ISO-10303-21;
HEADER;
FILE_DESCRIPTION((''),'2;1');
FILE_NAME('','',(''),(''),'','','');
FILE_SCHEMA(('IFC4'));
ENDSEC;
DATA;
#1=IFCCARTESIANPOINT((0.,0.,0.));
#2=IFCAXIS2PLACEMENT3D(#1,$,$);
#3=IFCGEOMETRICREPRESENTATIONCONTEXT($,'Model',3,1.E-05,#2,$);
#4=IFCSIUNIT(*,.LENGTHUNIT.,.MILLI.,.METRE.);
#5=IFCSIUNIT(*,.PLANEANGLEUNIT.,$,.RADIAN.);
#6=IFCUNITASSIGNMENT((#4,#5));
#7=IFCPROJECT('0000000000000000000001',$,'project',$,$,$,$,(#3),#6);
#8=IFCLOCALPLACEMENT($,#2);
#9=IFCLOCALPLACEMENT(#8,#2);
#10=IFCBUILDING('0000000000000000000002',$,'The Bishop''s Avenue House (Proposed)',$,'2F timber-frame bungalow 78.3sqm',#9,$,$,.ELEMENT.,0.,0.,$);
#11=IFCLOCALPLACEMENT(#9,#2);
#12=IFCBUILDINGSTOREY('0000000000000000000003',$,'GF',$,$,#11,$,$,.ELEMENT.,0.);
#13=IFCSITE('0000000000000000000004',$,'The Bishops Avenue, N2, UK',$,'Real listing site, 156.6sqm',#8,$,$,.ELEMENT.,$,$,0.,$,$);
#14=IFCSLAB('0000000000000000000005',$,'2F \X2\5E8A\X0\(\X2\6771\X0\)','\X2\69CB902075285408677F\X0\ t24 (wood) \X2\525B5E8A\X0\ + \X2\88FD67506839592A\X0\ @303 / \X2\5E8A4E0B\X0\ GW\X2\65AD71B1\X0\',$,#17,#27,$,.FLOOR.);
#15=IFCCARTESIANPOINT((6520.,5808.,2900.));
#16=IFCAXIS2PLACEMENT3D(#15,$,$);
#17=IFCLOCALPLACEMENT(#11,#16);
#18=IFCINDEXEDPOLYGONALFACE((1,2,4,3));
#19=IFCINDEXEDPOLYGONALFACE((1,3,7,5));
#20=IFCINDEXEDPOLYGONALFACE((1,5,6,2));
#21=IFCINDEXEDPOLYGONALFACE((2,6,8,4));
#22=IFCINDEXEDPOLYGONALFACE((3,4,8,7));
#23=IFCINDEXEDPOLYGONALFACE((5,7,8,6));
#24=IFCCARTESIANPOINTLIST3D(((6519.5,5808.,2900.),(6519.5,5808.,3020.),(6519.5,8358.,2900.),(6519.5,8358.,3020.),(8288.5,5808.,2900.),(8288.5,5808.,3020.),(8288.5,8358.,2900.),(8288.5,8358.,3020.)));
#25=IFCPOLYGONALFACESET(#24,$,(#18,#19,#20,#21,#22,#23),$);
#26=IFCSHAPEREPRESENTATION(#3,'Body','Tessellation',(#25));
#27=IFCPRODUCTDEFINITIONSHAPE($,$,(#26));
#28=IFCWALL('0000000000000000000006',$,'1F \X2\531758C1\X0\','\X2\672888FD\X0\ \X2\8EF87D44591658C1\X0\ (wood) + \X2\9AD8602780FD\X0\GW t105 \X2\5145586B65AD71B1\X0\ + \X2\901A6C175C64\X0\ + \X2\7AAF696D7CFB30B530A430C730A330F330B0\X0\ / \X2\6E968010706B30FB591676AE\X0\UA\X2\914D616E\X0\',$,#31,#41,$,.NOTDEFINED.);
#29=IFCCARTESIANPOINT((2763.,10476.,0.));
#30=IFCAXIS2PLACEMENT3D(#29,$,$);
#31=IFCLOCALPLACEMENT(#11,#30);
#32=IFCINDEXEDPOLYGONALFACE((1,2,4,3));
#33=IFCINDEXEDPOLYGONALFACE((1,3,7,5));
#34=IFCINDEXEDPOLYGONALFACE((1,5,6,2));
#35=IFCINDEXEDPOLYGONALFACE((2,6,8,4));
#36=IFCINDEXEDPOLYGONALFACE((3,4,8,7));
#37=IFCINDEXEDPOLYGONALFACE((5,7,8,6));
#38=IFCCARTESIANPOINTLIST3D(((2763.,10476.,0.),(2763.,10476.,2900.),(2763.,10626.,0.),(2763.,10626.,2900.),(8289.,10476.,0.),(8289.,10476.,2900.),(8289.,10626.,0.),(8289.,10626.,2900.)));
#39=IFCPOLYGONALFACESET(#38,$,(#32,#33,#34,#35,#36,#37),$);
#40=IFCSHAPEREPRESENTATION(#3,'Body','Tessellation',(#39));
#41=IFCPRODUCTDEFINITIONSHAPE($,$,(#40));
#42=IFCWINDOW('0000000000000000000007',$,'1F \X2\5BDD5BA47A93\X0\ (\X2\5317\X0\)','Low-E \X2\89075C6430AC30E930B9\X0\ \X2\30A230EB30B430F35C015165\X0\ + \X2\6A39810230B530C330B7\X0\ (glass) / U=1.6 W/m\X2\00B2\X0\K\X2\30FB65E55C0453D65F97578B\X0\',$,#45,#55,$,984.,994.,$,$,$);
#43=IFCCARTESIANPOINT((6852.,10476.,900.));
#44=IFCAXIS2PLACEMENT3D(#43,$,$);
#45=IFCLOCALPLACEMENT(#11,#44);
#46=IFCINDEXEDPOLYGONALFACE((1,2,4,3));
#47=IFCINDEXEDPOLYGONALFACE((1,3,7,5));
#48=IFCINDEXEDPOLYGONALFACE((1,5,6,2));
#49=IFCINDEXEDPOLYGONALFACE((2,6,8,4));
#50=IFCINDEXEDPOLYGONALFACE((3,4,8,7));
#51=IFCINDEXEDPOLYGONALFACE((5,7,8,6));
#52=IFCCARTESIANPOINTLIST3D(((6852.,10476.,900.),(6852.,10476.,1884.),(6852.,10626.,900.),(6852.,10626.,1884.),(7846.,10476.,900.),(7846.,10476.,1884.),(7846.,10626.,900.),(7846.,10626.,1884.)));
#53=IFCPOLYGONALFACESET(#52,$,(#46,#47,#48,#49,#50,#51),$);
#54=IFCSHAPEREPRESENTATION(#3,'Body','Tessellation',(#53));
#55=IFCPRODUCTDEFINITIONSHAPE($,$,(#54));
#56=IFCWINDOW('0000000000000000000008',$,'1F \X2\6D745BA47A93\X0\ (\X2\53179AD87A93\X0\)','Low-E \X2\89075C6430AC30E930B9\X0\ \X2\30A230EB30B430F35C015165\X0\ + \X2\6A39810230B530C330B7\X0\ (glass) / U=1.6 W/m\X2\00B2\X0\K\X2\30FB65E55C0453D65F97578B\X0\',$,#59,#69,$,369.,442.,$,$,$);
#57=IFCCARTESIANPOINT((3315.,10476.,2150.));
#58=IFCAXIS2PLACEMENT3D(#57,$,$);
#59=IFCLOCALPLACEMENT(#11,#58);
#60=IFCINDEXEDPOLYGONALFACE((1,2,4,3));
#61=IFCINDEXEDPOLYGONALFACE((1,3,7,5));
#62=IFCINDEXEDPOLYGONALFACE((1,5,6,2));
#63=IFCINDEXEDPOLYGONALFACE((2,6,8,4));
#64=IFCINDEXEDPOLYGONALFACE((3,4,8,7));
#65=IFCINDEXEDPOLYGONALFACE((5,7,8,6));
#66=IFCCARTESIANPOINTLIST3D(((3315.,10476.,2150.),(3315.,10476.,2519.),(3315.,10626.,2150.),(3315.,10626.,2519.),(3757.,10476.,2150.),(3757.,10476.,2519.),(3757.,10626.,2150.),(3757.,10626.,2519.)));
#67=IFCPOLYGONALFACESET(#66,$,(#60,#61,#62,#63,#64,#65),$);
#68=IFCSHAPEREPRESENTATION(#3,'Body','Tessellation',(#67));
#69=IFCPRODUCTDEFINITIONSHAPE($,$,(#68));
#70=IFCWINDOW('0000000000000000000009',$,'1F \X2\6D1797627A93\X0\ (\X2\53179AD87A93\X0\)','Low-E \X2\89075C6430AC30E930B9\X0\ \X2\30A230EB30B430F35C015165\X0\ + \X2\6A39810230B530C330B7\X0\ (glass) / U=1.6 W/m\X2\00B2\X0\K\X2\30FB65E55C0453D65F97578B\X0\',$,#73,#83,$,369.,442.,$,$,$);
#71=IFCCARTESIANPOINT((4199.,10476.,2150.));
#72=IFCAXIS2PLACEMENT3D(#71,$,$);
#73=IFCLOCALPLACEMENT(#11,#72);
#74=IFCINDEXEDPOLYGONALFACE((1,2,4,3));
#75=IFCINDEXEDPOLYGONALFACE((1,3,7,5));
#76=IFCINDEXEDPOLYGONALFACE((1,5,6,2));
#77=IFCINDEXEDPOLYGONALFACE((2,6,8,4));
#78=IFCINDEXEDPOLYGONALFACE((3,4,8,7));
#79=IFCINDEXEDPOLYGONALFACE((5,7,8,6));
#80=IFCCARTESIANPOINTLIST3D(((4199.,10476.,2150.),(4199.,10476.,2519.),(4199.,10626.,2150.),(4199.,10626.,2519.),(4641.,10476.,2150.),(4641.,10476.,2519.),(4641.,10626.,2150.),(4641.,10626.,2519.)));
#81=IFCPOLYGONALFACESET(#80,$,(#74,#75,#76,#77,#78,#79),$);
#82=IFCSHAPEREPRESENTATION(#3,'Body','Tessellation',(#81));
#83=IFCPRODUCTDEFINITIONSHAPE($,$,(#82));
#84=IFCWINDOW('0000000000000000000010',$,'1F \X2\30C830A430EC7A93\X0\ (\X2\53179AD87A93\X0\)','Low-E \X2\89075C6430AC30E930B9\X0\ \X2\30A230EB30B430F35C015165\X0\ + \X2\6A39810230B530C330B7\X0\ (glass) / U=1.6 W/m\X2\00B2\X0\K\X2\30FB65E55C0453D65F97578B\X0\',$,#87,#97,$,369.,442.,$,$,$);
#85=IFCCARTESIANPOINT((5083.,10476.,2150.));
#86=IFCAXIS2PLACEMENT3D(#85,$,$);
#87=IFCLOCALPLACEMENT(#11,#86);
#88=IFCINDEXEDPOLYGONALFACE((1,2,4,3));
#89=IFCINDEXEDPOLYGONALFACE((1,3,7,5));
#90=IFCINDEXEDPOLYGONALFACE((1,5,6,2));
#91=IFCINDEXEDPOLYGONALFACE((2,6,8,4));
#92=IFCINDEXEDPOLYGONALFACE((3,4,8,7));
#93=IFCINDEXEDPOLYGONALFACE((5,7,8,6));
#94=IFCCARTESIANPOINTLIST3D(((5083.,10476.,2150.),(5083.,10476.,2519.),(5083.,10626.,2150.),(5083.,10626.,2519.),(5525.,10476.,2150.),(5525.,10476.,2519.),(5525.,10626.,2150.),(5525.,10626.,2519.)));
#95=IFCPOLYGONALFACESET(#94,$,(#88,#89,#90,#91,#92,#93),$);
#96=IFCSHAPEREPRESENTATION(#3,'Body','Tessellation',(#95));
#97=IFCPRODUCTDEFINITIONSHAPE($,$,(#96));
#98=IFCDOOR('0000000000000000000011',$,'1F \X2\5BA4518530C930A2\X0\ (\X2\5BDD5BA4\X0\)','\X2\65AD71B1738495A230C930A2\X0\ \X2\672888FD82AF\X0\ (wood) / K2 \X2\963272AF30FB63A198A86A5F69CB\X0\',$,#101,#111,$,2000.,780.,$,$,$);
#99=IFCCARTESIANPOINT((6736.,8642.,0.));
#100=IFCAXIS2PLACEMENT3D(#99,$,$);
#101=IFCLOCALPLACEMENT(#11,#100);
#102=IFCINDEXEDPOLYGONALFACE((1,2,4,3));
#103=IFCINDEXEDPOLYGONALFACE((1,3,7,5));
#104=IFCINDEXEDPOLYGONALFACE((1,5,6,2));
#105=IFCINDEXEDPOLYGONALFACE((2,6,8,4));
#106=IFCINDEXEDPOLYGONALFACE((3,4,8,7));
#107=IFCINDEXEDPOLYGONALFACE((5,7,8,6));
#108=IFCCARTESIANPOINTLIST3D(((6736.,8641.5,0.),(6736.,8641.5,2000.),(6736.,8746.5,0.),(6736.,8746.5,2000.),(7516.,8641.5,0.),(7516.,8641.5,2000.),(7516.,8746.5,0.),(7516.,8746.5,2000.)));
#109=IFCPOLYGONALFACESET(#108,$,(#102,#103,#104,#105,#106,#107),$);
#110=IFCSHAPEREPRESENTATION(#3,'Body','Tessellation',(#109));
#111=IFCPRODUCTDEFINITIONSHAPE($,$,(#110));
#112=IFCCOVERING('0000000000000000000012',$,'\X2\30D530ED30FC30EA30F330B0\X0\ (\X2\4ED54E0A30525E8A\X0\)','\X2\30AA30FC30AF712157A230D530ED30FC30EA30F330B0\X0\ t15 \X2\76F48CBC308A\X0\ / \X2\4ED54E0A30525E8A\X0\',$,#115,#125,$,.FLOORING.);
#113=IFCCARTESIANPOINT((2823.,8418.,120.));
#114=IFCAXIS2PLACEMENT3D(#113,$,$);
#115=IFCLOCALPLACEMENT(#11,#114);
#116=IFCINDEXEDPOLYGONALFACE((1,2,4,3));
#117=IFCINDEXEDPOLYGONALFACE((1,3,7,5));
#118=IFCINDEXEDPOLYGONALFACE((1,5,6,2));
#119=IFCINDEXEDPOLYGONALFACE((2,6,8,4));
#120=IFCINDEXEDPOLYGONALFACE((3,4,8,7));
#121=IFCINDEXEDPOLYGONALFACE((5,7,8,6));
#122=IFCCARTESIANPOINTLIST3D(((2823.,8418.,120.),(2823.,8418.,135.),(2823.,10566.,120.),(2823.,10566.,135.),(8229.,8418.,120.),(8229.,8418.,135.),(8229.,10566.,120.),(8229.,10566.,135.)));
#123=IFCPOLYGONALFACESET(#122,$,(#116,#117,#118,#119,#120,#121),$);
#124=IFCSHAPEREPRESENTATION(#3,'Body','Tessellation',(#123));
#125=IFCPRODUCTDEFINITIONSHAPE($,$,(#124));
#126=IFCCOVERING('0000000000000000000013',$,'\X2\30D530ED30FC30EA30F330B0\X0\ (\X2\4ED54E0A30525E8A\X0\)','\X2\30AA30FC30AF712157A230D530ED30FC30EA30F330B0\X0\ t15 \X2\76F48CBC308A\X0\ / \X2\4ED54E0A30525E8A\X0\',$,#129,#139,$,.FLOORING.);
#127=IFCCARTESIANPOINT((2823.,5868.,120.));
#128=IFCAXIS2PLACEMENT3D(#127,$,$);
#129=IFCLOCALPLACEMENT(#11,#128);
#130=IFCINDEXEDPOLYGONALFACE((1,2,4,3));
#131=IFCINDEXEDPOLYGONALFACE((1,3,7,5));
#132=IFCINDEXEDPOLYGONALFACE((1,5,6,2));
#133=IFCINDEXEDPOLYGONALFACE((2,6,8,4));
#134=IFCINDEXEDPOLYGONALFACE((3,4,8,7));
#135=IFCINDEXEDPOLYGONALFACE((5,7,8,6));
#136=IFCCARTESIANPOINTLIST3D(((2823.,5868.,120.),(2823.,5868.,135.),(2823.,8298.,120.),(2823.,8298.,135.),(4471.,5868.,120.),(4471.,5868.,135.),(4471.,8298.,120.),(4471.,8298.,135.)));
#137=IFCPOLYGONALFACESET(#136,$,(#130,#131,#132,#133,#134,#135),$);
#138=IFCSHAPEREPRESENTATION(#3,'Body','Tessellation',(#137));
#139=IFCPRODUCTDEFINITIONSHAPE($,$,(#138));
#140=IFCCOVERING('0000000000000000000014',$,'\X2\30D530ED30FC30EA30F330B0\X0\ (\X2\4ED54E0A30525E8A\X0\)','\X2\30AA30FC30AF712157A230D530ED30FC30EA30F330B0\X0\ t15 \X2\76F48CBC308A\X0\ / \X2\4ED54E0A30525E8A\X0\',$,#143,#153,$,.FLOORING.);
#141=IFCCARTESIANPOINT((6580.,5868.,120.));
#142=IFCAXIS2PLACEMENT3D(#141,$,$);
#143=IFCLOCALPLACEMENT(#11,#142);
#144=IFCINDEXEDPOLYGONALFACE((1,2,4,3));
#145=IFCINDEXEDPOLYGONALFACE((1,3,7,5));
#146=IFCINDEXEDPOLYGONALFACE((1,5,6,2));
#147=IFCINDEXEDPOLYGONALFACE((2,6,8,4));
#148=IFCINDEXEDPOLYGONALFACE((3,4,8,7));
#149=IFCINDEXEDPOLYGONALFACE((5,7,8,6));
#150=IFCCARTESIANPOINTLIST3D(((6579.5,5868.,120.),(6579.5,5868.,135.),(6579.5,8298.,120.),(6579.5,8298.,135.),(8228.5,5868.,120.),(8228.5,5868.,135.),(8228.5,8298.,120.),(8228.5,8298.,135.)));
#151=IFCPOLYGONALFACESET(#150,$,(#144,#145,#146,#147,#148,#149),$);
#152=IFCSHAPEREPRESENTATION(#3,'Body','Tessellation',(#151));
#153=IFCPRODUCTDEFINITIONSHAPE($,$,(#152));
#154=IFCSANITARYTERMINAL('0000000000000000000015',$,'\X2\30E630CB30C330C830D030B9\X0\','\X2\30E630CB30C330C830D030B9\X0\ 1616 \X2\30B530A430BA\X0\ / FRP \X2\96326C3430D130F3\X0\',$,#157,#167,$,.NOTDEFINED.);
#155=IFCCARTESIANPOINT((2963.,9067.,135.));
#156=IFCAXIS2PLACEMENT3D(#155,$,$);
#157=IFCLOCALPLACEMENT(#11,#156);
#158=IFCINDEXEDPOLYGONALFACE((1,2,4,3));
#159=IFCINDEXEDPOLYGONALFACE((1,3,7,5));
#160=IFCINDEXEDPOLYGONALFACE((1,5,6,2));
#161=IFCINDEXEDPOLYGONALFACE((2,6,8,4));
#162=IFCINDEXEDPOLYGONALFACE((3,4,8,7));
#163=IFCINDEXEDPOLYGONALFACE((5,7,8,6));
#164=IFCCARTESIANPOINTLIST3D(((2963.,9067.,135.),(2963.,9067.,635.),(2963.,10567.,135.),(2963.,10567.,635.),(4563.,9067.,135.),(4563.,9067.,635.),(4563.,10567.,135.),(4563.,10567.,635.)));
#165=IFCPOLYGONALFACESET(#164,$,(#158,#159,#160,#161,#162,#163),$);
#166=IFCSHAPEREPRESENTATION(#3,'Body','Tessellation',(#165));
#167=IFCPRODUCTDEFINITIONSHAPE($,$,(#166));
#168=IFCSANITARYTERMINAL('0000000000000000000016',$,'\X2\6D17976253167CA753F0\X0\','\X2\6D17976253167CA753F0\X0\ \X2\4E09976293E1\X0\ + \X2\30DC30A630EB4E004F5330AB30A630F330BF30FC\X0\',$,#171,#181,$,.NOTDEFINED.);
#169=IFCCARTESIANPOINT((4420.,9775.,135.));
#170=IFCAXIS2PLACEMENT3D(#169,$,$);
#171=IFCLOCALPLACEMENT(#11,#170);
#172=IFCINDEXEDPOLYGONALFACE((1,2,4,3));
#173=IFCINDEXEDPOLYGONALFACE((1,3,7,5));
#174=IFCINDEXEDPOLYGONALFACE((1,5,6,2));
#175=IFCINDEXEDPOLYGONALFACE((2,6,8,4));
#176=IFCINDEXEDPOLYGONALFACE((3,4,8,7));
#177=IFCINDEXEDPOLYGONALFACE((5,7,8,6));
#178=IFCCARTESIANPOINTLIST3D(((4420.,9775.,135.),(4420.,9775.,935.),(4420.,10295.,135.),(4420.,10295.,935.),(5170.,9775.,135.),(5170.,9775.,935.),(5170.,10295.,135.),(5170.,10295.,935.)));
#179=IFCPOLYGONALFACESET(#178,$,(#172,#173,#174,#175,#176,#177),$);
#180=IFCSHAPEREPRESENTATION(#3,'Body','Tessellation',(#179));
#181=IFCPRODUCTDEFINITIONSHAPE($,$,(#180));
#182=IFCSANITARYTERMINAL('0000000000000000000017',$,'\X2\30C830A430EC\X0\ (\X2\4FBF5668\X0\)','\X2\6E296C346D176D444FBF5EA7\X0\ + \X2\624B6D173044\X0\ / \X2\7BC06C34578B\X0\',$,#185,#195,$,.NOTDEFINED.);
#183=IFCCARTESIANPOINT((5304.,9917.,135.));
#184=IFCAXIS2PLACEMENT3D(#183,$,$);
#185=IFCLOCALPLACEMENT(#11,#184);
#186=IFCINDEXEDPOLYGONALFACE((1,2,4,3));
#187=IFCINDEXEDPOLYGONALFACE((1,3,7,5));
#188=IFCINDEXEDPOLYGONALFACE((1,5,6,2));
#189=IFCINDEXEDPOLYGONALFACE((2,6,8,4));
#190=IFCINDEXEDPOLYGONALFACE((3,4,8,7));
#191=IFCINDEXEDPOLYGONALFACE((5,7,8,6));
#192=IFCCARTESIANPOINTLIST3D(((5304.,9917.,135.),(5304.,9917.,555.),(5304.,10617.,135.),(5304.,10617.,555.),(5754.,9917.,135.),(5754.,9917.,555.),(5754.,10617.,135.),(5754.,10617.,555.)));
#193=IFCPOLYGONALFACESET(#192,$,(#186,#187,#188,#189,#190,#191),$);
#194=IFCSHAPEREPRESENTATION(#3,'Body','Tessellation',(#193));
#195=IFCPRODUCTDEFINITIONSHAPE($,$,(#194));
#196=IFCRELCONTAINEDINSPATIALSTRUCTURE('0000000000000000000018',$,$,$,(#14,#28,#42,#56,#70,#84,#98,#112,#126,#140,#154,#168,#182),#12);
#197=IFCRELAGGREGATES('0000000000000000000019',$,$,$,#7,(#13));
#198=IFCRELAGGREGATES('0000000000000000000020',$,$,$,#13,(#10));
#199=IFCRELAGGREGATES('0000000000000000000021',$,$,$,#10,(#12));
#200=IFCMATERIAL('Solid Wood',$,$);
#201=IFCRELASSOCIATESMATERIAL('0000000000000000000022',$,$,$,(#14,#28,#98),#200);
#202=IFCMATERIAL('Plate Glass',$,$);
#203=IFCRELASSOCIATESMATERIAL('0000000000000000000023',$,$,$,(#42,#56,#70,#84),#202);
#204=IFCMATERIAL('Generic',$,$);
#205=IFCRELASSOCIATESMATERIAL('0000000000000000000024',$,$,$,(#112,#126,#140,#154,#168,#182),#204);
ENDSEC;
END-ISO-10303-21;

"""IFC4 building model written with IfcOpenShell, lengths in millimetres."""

from ifc_helpers import new_model, si_unit, frame, frame_2d, origin, place, context, project, spatial, rectangle, extrude, material, element, fill, save


model = new_model("IFC4")

# Units and contexts
model_context = context("Model", 3, precision=1e-05, world=origin())
ifc_project = project(units=[si_unit("LENGTHUNIT", "METRE", prefix="MILLI"), si_unit("PLANEANGLEUNIT", "RADIAN")], contexts=[model_context])

# Site, building, storey
site_placement = place(None, origin())
site = spatial("IfcSite", under=ifc_project, at=site_placement, Name="The Bishops Avenue, N2, UK", ObjectType="Real listing site, 156.6sqm", CompositionType="ELEMENT", RefElevation=0.0)
building_placement = place(site_placement, origin())
building = spatial("IfcBuilding", under=site, at=building_placement, Name="The Bishop's Avenue House (Proposed)", ObjectType="2F timber-frame bungalow 78.3sqm", CompositionType="ELEMENT", ElevationOfRefHeight=0.0, ElevationOfTerrain=0.0)
storey_placement = place(building_placement, origin())
storey = spatial("IfcBuildingStorey", under=building, at=storey_placement, Name="GF", CompositionType="ELEMENT", Elevation=0.0)

# Slab
ifc_material_1 = material(Name="Solid Wood")
slab_1_placement = place(storey_placement, frame((6520.0, 5808.0, 2900.0)))
element("IfcSlab", 1, at=slab_1_placement, inside=storey, material=ifc_material_1, Name="2F 床(東)", Description="構造用合板 t24 (wood) 剛床 + 製材根太 @303 / 床下 GW断熱", PredefinedType="FLOOR", context=model_context, shape_type="SweptSolid", body=[
    extrude(rectangle(XDim=1769.0, YDim=2550.0, at=frame_2d((884.0, 1275.0))), frame((6520.0, 5808.0, 2900.0)), (0.0, 0.0, 1.0), 120.0),
])

# Wall, openings, windows
wall_1_placement = place(storey_placement, frame((2763.0, 10476.0, 0.0)))
wall_1 = element("IfcWall", 2, at=wall_1_placement, inside=storey, material=ifc_material_1, Name="1F 北壁", Description="木製 軸組外壁 (wood) + 高性能GW t105 充填断熱 + 通気層 + 窯業系サイディング / 準耐火・外皮UA配慮", PredefinedType="NOTDEFINED", context=model_context, shape_type="SweptSolid", body=[
    extrude(rectangle(XDim=5526.0, YDim=150.0, at=frame_2d((2763.0, 75.0))), frame((2763.0, 10476.0, 0.0)), (0.0, 0.0, 1.0), 2900.0),
])
opening_1_placement = place(storey_placement, frame((6852.0, 10476.0, 900.0)))
opening_1 = element("IfcOpeningElement", 3, at=opening_1_placement, cuts=wall_1, PredefinedType="NOTDEFINED", context=model_context, shape_type="SweptSolid", body=[
    extrude(rectangle(XDim=994.0, YDim=150.0, at=frame_2d((497.0, 75.0))), frame((6852.0, 10476.0, 900.0)), (0.0, 0.0, 1.0), 984.0),
])
opening_2_placement = place(storey_placement, frame((3315.0, 10476.0, 2150.0)))
opening_2 = element("IfcOpeningElement", 4, at=opening_2_placement, cuts=wall_1, PredefinedType="NOTDEFINED", context=model_context, shape_type="SweptSolid", body=[
    extrude(rectangle(XDim=442.0, YDim=150.0, at=frame_2d((221.0, 75.0))), frame((3315.0, 10476.0, 2150.0)), (0.0, 0.0, 1.0), 369.0),
])
opening_3_placement = place(storey_placement, frame((4199.0, 10476.0, 2150.0)))
opening_3 = element("IfcOpeningElement", 5, at=opening_3_placement, cuts=wall_1, PredefinedType="NOTDEFINED", context=model_context, shape_type="SweptSolid", body=[
    extrude(rectangle(XDim=442.0, YDim=150.0, at=frame_2d((221.0, 75.0))), frame((4199.0, 10476.0, 2150.0)), (0.0, 0.0, 1.0), 369.0),
])
opening_4_placement = place(storey_placement, frame((5083.0, 10476.0, 2150.0)))
opening_4 = element("IfcOpeningElement", 6, at=opening_4_placement, cuts=wall_1, PredefinedType="NOTDEFINED", context=model_context, shape_type="SweptSolid", body=[
    extrude(rectangle(XDim=442.0, YDim=150.0, at=frame_2d((221.0, 75.0))), frame((5083.0, 10476.0, 2150.0)), (0.0, 0.0, 1.0), 369.0),
])
ifc_material_2 = material(Name="Plate Glass")
window_1_placement = place(storey_placement, frame((6852.0, 10476.0, 900.0)))
window_1 = element("IfcWindow", 7, at=window_1_placement, inside=storey, material=ifc_material_2, Name="1F 寝室窓 (北)", Description="Low-E 複層ガラス アルゴン封入 + 樹脂サッシ (glass) / U=1.6 W/m²K・日射取得型", OverallHeight=984.0, OverallWidth=994.0, context=model_context, shape_type="SweptSolid", body=[
    extrude(rectangle(XDim=994.0, YDim=150.0, at=frame_2d((497.0, 75.0))), frame((6852.0, 10476.0, 900.0)), (0.0, 0.0, 1.0), 984.0),
])
fill(opening_1, window_1)
window_2_placement = place(storey_placement, frame((3315.0, 10476.0, 2150.0)))
window_2 = element("IfcWindow", 8, at=window_2_placement, inside=storey, material=ifc_material_2, Name="1F 浴室窓 (北高窓)", Description="Low-E 複層ガラス アルゴン封入 + 樹脂サッシ (glass) / U=1.6 W/m²K・日射取得型", OverallHeight=369.0, OverallWidth=442.0, context=model_context, shape_type="SweptSolid", body=[
    extrude(rectangle(XDim=442.0, YDim=150.0, at=frame_2d((221.0, 75.0))), frame((3315.0, 10476.0, 2150.0)), (0.0, 0.0, 1.0), 369.0),
])
fill(opening_2, window_2)
window_3_placement = place(storey_placement, frame((4199.0, 10476.0, 2150.0)))
window_3 = element("IfcWindow", 9, at=window_3_placement, inside=storey, material=ifc_material_2, Name="1F 洗面窓 (北高窓)", Description="Low-E 複層ガラス アルゴン封入 + 樹脂サッシ (glass) / U=1.6 W/m²K・日射取得型", OverallHeight=369.0, OverallWidth=442.0, context=model_context, shape_type="SweptSolid", body=[
    extrude(rectangle(XDim=442.0, YDim=150.0, at=frame_2d((221.0, 75.0))), frame((4199.0, 10476.0, 2150.0)), (0.0, 0.0, 1.0), 369.0),
])
fill(opening_3, window_3)
window_4_placement = place(storey_placement, frame((5083.0, 10476.0, 2150.0)))
window_4 = element("IfcWindow", 10, at=window_4_placement, inside=storey, material=ifc_material_2, Name="1F トイレ窓 (北高窓)", Description="Low-E 複層ガラス アルゴン封入 + 樹脂サッシ (glass) / U=1.6 W/m²K・日射取得型", OverallHeight=369.0, OverallWidth=442.0, context=model_context, shape_type="SweptSolid", body=[
    extrude(rectangle(XDim=442.0, YDim=150.0, at=frame_2d((221.0, 75.0))), frame((5083.0, 10476.0, 2150.0)), (0.0, 0.0, 1.0), 369.0),
])
fill(opening_4, window_4)

# Door
door_1_placement = place(storey_placement, frame((6736.0, 8642.0, 0.0)))
element("IfcDoor", 11, at=door_1_placement, inside=storey, material=ifc_material_1, Name="1F 室内ドア (寝室)", Description="断熱玄関ドア 木製芯 (wood) / K2 防犯・採風機構", OverallHeight=2000.0, OverallWidth=780.0, context=model_context, shape_type="SweptSolid", body=[
    extrude(rectangle(XDim=780.0, YDim=105.0, at=frame_2d((390.0, 52.0))), frame((6736.0, 8642.0, 0.0)), (0.0, 0.0, 1.0), 2000.0),
])

# Coverings
ifc_material_3 = material(Name="Generic")
covering_1_placement = place(storey_placement, frame((2823.0, 8418.0, 120.0)))
element("IfcCovering", 12, at=covering_1_placement, inside=storey, material=ifc_material_3, Name="フローリング (仕上げ床)", Description="オーク無垢フローリング t15 直貼り / 仕上げ床", PredefinedType="FLOORING", context=model_context, shape_type="SweptSolid", body=[
    extrude(rectangle(XDim=5406.0, YDim=2148.0, at=frame_2d((2703.0, 1074.0))), frame((2823.0, 8418.0, 120.0)), (0.0, 0.0, 1.0), 15.0),
])
covering_2_placement = place(storey_placement, frame((2823.0, 5868.0, 120.0)))
element("IfcCovering", 13, at=covering_2_placement, inside=storey, material=ifc_material_3, Name="フローリング (仕上げ床)", Description="オーク無垢フローリング t15 直貼り / 仕上げ床", PredefinedType="FLOORING", context=model_context, shape_type="SweptSolid", body=[
    extrude(rectangle(XDim=1648.0, YDim=2430.0, at=frame_2d((824.0, 1215.0))), frame((2823.0, 5868.0, 120.0)), (0.0, 0.0, 1.0), 15.0),
])
covering_3_placement = place(storey_placement, frame((6580.0, 5868.0, 120.0)))
element("IfcCovering", 14, at=covering_3_placement, inside=storey, material=ifc_material_3, Name="フローリング (仕上げ床)", Description="オーク無垢フローリング t15 直貼り / 仕上げ床", PredefinedType="FLOORING", context=model_context, shape_type="SweptSolid", body=[
    extrude(rectangle(XDim=1649.0, YDim=2430.0, at=frame_2d((824.0, 1215.0))), frame((6580.0, 5868.0, 120.0)), (0.0, 0.0, 1.0), 15.0),
])

# Sanitary terminals
sanitary_terminal_1_placement = place(storey_placement, frame((2963.0, 9067.0, 135.0)))
element("IfcSanitaryTerminal", 15, at=sanitary_terminal_1_placement, inside=storey, material=ifc_material_3, Name="ユニットバス", Description="ユニットバス 1616 サイズ / FRP 防水パン", PredefinedType="NOTDEFINED", context=model_context, shape_type="SweptSolid", body=[
    extrude(rectangle(XDim=1600.0, YDim=1500.0, at=frame_2d((800.0, 750.0))), frame((2963.0, 9067.0, 135.0)), (0.0, 0.0, 1.0), 500.0),
])
sanitary_terminal_2_placement = place(storey_placement, frame((4420.0, 9775.0, 135.0)))
element("IfcSanitaryTerminal", 16, at=sanitary_terminal_2_placement, inside=storey, material=ifc_material_3, Name="洗面化粧台", Description="洗面化粧台 三面鏡 + ボウル一体カウンター", PredefinedType="NOTDEFINED", context=model_context, shape_type="SweptSolid", body=[
    extrude(rectangle(XDim=750.0, YDim=520.0, at=frame_2d((375.0, 260.0))), frame((4420.0, 9775.0, 135.0)), (0.0, 0.0, 1.0), 800.0),
])
sanitary_terminal_3_placement = place(storey_placement, frame((5304.0, 9917.0, 135.0)))
element("IfcSanitaryTerminal", 17, at=sanitary_terminal_3_placement, inside=storey, material=ifc_material_3, Name="トイレ (便器)", Description="温水洗浄便座 + 手洗い / 節水型", PredefinedType="NOTDEFINED", context=model_context, shape_type="SweptSolid", body=[
    extrude(rectangle(XDim=450.0, YDim=700.0, at=frame_2d((225.0, 350.0))), frame((5304.0, 9917.0, 135.0)), (0.0, 0.0, 1.0), 420.0),
])

save(model, "model.ifc")
